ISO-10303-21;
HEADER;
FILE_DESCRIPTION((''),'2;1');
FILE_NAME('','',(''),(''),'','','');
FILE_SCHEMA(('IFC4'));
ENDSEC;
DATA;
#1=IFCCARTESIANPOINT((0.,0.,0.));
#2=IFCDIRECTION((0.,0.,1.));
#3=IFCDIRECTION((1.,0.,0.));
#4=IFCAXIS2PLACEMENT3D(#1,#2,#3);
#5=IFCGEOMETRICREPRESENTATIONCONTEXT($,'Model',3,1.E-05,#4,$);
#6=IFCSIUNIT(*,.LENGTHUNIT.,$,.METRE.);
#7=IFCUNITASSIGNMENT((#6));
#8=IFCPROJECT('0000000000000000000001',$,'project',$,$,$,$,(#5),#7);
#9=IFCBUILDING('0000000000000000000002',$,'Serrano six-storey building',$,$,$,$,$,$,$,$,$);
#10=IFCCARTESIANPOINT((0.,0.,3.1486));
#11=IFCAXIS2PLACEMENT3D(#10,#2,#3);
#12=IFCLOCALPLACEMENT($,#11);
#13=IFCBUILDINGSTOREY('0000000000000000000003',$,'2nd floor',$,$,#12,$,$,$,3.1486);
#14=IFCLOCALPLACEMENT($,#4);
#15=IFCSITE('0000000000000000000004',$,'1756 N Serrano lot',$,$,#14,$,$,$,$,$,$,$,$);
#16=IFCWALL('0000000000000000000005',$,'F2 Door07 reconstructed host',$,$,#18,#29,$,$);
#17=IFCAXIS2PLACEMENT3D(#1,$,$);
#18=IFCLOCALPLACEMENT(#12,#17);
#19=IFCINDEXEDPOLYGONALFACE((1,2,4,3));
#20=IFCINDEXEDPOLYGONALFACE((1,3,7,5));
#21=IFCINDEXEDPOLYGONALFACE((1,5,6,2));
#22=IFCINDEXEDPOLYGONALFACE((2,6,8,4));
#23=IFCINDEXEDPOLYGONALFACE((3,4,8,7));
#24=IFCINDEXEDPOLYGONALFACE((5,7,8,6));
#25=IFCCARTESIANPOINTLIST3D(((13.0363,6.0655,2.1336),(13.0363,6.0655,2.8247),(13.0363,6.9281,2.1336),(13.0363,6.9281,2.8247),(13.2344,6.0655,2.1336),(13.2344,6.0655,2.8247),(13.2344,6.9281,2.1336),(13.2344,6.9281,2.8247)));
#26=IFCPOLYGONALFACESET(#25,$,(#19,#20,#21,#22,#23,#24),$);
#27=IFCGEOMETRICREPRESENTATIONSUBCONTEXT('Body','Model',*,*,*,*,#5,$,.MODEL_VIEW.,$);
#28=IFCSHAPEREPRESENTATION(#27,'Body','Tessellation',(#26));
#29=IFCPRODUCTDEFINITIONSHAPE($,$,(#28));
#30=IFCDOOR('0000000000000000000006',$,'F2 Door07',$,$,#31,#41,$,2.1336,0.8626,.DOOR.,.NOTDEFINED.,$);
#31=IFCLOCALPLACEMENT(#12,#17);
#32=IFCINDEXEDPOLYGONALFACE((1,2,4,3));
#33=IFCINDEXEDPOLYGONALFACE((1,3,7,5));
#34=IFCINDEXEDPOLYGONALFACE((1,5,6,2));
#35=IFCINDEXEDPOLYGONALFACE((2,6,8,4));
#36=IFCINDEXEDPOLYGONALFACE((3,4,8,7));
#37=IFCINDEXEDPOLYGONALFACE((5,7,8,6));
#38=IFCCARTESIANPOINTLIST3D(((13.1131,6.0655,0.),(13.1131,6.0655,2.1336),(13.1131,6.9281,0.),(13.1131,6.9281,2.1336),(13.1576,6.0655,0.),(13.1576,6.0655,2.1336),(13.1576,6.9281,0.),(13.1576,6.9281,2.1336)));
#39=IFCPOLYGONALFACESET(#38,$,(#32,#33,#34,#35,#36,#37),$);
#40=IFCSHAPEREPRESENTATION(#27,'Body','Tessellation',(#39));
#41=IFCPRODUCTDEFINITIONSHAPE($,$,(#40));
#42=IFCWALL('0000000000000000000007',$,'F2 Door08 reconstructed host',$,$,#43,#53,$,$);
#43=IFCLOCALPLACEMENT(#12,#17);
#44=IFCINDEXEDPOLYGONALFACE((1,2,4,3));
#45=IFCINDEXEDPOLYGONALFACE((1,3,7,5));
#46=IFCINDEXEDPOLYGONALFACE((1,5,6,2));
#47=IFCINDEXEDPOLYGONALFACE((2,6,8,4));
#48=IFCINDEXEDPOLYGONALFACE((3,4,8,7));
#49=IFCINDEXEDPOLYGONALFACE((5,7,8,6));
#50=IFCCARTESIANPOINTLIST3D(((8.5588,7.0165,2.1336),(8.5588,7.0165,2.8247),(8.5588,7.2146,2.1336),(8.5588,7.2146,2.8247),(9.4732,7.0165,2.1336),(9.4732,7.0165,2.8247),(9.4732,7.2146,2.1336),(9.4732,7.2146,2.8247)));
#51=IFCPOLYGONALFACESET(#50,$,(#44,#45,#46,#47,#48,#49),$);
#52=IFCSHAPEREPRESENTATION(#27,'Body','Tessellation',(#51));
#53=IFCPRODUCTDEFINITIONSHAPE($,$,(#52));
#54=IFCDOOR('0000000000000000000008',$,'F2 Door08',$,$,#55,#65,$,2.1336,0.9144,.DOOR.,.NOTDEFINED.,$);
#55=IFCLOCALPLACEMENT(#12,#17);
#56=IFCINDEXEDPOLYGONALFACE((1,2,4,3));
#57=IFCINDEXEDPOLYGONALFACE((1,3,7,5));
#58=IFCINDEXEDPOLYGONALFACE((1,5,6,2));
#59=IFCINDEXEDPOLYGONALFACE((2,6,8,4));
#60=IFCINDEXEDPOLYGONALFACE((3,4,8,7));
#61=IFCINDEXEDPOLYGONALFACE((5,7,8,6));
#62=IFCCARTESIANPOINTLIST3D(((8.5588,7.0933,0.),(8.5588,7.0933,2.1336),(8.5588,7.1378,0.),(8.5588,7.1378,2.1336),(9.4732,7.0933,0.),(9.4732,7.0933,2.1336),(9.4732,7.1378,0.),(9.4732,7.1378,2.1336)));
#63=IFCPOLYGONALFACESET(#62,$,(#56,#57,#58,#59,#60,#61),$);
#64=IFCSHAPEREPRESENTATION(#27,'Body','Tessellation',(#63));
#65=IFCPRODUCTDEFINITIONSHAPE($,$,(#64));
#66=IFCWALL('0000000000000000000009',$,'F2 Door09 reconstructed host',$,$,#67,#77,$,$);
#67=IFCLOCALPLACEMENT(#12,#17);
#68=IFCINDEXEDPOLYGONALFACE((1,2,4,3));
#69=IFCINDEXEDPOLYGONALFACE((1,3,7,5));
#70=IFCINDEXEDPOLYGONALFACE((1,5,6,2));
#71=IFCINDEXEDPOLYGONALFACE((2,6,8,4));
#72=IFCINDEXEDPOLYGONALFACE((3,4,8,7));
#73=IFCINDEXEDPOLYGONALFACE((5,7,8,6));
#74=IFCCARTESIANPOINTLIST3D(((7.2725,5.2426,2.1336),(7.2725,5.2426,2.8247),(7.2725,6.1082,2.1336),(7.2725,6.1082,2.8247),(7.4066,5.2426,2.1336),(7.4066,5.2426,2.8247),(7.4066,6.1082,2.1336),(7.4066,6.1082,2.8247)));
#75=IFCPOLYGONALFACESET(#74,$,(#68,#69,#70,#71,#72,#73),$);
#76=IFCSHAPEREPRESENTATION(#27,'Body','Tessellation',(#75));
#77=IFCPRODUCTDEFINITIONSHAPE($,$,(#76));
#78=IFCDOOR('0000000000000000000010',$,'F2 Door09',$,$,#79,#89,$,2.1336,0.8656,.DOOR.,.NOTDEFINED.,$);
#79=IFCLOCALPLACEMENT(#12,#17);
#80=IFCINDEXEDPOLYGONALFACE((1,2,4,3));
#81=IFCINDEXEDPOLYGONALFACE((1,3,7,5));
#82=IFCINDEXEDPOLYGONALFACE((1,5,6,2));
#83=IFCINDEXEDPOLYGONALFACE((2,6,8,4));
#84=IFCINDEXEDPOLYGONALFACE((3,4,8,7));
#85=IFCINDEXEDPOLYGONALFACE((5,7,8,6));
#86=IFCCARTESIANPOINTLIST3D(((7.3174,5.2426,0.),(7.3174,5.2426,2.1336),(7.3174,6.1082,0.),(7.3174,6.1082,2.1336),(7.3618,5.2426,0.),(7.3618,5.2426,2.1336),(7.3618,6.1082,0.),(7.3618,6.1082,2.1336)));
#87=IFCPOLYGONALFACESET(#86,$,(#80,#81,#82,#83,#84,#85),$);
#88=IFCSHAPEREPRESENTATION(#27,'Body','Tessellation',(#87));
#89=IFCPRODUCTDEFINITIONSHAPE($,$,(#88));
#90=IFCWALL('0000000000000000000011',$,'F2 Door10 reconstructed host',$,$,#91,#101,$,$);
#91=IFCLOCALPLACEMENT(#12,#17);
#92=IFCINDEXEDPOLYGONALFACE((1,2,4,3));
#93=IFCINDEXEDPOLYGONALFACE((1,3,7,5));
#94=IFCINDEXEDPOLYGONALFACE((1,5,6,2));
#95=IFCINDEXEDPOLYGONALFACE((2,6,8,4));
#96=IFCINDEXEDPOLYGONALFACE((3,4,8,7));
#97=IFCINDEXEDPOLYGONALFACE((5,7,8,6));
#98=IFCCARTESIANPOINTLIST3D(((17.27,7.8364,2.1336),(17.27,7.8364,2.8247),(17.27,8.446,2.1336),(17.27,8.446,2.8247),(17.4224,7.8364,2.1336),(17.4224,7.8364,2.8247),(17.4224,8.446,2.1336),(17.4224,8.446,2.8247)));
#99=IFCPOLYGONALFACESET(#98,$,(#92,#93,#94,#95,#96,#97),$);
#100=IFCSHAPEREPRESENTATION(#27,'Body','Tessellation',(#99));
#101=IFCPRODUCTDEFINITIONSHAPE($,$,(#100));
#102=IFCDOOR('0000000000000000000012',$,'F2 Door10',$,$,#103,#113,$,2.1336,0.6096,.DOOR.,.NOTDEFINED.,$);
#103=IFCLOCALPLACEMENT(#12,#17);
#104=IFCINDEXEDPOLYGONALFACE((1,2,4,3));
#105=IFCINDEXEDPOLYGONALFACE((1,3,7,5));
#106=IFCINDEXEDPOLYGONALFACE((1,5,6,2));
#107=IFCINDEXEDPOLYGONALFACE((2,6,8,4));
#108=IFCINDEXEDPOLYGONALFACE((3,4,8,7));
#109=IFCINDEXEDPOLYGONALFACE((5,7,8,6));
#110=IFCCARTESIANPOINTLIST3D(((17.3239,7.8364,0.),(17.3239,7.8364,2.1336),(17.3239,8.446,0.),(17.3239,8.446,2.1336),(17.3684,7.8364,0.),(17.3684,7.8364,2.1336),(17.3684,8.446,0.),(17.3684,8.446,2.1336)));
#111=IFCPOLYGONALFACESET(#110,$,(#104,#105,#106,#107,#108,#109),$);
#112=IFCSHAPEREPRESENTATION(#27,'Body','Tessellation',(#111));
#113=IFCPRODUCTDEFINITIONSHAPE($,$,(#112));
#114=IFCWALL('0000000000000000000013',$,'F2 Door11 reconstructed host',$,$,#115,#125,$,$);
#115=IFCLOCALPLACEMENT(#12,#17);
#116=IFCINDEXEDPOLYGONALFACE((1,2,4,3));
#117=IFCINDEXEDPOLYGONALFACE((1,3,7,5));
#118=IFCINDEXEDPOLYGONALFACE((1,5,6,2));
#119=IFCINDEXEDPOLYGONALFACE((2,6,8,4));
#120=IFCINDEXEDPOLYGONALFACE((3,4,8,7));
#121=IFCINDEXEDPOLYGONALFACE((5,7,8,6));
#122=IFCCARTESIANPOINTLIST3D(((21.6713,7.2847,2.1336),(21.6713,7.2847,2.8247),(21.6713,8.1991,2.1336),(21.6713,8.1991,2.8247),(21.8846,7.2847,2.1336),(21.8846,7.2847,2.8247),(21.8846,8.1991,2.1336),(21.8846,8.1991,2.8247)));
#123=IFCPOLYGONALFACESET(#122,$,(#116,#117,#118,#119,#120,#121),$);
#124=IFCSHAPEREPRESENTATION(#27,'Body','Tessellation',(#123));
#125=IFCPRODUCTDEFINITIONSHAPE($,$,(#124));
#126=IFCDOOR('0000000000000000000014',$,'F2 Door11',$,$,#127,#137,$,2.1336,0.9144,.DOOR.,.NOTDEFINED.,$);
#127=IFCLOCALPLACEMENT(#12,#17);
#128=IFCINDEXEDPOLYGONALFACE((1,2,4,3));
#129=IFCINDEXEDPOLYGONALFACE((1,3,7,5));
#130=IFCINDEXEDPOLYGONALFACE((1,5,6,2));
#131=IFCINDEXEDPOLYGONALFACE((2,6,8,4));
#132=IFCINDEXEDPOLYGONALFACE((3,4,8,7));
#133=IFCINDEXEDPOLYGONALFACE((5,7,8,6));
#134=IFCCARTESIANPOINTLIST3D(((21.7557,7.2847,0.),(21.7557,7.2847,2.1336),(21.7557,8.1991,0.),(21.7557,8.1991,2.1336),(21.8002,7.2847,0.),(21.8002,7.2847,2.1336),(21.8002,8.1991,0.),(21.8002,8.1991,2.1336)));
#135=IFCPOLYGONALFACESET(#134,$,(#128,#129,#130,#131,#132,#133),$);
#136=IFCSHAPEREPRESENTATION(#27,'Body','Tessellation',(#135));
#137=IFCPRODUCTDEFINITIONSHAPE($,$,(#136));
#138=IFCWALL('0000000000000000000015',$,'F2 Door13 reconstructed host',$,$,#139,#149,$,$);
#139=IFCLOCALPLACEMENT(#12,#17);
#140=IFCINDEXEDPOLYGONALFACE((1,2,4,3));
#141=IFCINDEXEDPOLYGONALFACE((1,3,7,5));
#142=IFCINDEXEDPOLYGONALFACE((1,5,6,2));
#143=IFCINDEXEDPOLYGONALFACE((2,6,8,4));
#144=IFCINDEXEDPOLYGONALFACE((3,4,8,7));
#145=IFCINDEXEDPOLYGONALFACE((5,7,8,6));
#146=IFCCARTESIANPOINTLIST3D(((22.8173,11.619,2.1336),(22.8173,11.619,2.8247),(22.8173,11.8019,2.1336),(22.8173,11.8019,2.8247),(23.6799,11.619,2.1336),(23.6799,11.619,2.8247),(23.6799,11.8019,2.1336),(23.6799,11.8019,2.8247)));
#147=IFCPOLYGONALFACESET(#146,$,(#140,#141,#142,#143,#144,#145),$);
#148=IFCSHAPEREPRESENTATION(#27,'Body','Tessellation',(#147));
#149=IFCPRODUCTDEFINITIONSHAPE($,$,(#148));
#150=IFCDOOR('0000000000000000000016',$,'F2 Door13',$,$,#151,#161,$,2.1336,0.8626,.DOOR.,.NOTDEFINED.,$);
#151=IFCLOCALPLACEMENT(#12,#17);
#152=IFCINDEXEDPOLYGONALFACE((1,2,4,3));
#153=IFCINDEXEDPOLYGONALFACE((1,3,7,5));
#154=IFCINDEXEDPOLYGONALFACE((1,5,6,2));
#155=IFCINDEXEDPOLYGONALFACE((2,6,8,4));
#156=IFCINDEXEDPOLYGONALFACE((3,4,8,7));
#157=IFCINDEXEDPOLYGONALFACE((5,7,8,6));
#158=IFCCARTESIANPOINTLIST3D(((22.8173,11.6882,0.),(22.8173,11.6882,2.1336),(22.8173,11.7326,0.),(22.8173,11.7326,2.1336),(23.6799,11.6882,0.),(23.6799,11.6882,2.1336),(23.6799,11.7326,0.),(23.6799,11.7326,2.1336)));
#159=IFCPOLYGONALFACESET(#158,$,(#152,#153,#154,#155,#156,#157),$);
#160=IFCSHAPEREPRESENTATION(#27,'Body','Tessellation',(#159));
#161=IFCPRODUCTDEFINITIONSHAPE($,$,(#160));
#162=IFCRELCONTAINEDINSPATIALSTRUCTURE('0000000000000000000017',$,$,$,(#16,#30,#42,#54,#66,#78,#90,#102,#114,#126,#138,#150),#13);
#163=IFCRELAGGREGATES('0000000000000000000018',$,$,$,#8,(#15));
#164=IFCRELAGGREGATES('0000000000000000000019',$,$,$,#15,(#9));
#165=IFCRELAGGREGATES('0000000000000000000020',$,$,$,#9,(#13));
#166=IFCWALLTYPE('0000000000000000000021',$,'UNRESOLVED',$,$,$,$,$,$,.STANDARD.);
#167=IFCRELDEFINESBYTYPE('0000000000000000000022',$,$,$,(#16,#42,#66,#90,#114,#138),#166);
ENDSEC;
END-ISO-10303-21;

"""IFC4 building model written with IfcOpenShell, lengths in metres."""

from ifc_helpers import new_model, si_unit, frame, origin_with_axes, place, context, subcontext, project, spatial, polyline, outline, extrude, type_object, element, fill, save


model = new_model("IFC4")

# Units and contexts
model_context = context("Model", 3, precision=1e-05, world=origin_with_axes())
body_context = subcontext(model_context, "Body", "Model", "MODEL_VIEW")
ifc_project = project(units=[si_unit("LENGTHUNIT", "METRE")], contexts=[model_context])

# Site, building, storey
site_placement = place(None, origin_with_axes())
site = spatial("IfcSite", under=ifc_project, at=site_placement, Name="1756 N Serrano lot")
building = spatial("IfcBuilding", under=site, Name="Serrano six-storey building")
storey_placement = place(None, frame((0.0, 0.0, 3.1486), z_axis=(0.0, 0.0, 1.0), x_axis=(1.0, 0.0, 0.0)))
storey = spatial("IfcBuildingStorey", under=building, at=storey_placement, Name="2nd floor", Elevation=3.1486)

# Walls, openings, doors
wall_type_1 = type_object("IfcWallType", Name="UNRESOLVED", PredefinedType="STANDARD")
wall_1_placement = place(storey_placement, frame((0.0, 0.0, -3.1486), z_axis=(0.0, 0.0, 1.0), x_axis=(1.0, 0.0, 0.0)))
wall_1 = element("IfcWall", 1, at=wall_1_placement, inside=storey, type_object=wall_type_1, Name="F2 Door07 reconstructed host", context=body_context, shape_type="SweptSolid", body=[
    extrude(outline(polyline([(13.2344, 6.0655), (13.0363, 6.0655), (13.0363, 6.9281), (13.2344, 6.9281), (13.2344, 6.0655)])), frame((0.0, 0.0, 3.1486)), (0.0, 0.0, 1.0), 2.8247),
])
opening_1_placement = place(None, origin_with_axes())
opening_1 = element("IfcOpeningElement", 2, at=opening_1_placement, cuts=wall_1, PredefinedType="OPENING", context=body_context, shape_type="SweptSolid", body=[
    extrude(outline(polyline([(13.2527, 6.0655), (13.018, 6.0655), (13.018, 6.9281), (13.2527, 6.9281), (13.2527, 6.0655)])), frame((0.0, 0.0, 3.1486)), (0.0, 0.0, 1.0), 2.1336),
])
door_1_placement = place(storey_placement, frame((0.0, 0.0, -3.1486), z_axis=(0.0, 0.0, 1.0), x_axis=(1.0, 0.0, 0.0)))
door_1 = element("IfcDoor", 3, at=door_1_placement, inside=storey, Name="F2 Door07", OperationType="NOTDEFINED", OverallHeight=2.1336, OverallWidth=0.8626, PredefinedType="DOOR", context=body_context, shape_type="SweptSolid", body=[
    extrude(outline(polyline([(13.1576, 6.0655), (13.1131, 6.0655), (13.1131, 6.9281), (13.1576, 6.9281), (13.1576, 6.0655)])), frame((0.0, 0.0, 3.1486)), (0.0, 0.0, 1.0), 2.1336),
])
fill(opening_1, door_1)
wall_2_placement = place(storey_placement, frame((0.0, 0.0, -3.1486), z_axis=(0.0, 0.0, 1.0), x_axis=(1.0, 0.0, 0.0)))
wall_2 = element("IfcWall", 4, at=wall_2_placement, inside=storey, type_object=wall_type_1, Name="F2 Door08 reconstructed host", context=body_context, shape_type="SweptSolid", body=[
    extrude(outline(polyline([(9.4732, 7.2146), (9.4732, 7.0165), (8.5588, 7.0165), (8.5588, 7.2146), (9.4732, 7.2146)])), frame((0.0, 0.0, 3.1486)), (0.0, 0.0, 1.0), 2.8247),
])
opening_2_placement = place(None, origin_with_axes())
opening_2 = element("IfcOpeningElement", 5, at=opening_2_placement, cuts=wall_2, PredefinedType="OPENING", context=body_context, shape_type="SweptSolid", body=[
    extrude(outline(polyline([(9.4732, 7.2329), (9.4732, 6.9982), (8.5588, 6.9982), (8.5588, 7.2329), (9.4732, 7.2329)])), frame((0.0, 0.0, 3.1486)), (0.0, 0.0, 1.0), 2.1336),
])
door_2_placement = place(storey_placement, frame((0.0, 0.0, -3.1486), z_axis=(0.0, 0.0, 1.0), x_axis=(1.0, 0.0, 0.0)))
door_2 = element("IfcDoor", 6, at=door_2_placement, inside=storey, Name="F2 Door08", OperationType="NOTDEFINED", OverallHeight=2.1336, OverallWidth=0.9144, PredefinedType="DOOR", context=body_context, shape_type="SweptSolid", body=[
    extrude(outline(polyline([(9.4732, 7.1378), (9.4732, 7.0933), (8.5588, 7.0933), (8.5588, 7.1378), (9.4732, 7.1378)])), frame((0.0, 0.0, 3.1486)), (0.0, 0.0, 1.0), 2.1336),
])
fill(opening_2, door_2)
wall_3_placement = place(storey_placement, frame((0.0, 0.0, -3.1486), z_axis=(0.0, 0.0, 1.0), x_axis=(1.0, 0.0, 0.0)))
wall_3 = element("IfcWall", 7, at=wall_3_placement, inside=storey, type_object=wall_type_1, Name="F2 Door09 reconstructed host", context=body_context, shape_type="SweptSolid", body=[
    extrude(outline(polyline([(7.4066, 5.2426), (7.2725, 5.2426), (7.2725, 6.1082), (7.4066, 6.1082), (7.4066, 5.2426)])), frame((0.0, 0.0, 3.1486)), (0.0, 0.0, 1.0), 2.8247),
])
opening_3_placement = place(None, origin_with_axes())
opening_3 = element("IfcOpeningElement", 8, at=opening_3_placement, cuts=wall_3, PredefinedType="OPENING", context=body_context, shape_type="SweptSolid", body=[
    extrude(outline(polyline([(7.4249, 5.2426), (7.2542, 5.2426), (7.2542, 6.1082), (7.4249, 6.1082), (7.4249, 5.2426)])), frame((0.0, 0.0, 3.1486)), (0.0, 0.0, 1.0), 2.1336),
])
door_3_placement = place(storey_placement, frame((0.0, 0.0, -3.1486), z_axis=(0.0, 0.0, 1.0), x_axis=(1.0, 0.0, 0.0)))
door_3 = element("IfcDoor", 9, at=door_3_placement, inside=storey, Name="F2 Door09", OperationType="NOTDEFINED", OverallHeight=2.1336, OverallWidth=0.8656, PredefinedType="DOOR", context=body_context, shape_type="SweptSolid", body=[
    extrude(outline(polyline([(7.3618, 5.2426), (7.3174, 5.2426), (7.3174, 6.1082), (7.3618, 6.1082), (7.3618, 5.2426)])), frame((0.0, 0.0, 3.1486)), (0.0, 0.0, 1.0), 2.1336),
])
fill(opening_3, door_3)
wall_4_placement = place(storey_placement, frame((0.0, 0.0, -3.1486), z_axis=(0.0, 0.0, 1.0), x_axis=(1.0, 0.0, 0.0)))
wall_4 = element("IfcWall", 10, at=wall_4_placement, inside=storey, type_object=wall_type_1, Name="F2 Door10 reconstructed host", context=body_context, shape_type="SweptSolid", body=[
    extrude(outline(polyline([(17.4224, 7.8364), (17.27, 7.8364), (17.27, 8.446), (17.4224, 8.446), (17.4224, 7.8364)])), frame((0.0, 0.0, 3.1486)), (0.0, 0.0, 1.0), 2.8247),
])
opening_4_placement = place(None, origin_with_axes())
opening_4 = element("IfcOpeningElement", 11, at=opening_4_placement, cuts=wall_4, PredefinedType="OPENING", context=body_context, shape_type="SweptSolid", body=[
    extrude(outline(polyline([(17.4407, 7.8364), (17.2517, 7.8364), (17.2517, 8.446), (17.4407, 8.446), (17.4407, 7.8364)])), frame((0.0, 0.0, 3.1486)), (0.0, 0.0, 1.0), 2.1336),
])
door_4_placement = place(storey_placement, frame((0.0, 0.0, -3.1486), z_axis=(0.0, 0.0, 1.0), x_axis=(1.0, 0.0, 0.0)))
door_4 = element("IfcDoor", 12, at=door_4_placement, inside=storey, Name="F2 Door10", OperationType="NOTDEFINED", OverallHeight=2.1336, OverallWidth=0.6096, PredefinedType="DOOR", context=body_context, shape_type="SweptSolid", body=[
    extrude(outline(polyline([(17.3684, 7.8364), (17.3239, 7.8364), (17.3239, 8.446), (17.3684, 8.446), (17.3684, 7.8364)])), frame((0.0, 0.0, 3.1486)), (0.0, 0.0, 1.0), 2.1336),
])
fill(opening_4, door_4)
wall_5_placement = place(storey_placement, frame((0.0, 0.0, -3.1486), z_axis=(0.0, 0.0, 1.0), x_axis=(1.0, 0.0, 0.0)))
wall_5 = element("IfcWall", 13, at=wall_5_placement, inside=storey, type_object=wall_type_1, Name="F2 Door11 reconstructed host", context=body_context, shape_type="SweptSolid", body=[
    extrude(outline(polyline([(21.6713, 8.1991), (21.8846, 8.1991), (21.8846, 7.2847), (21.6713, 7.2847), (21.6713, 8.1991)])), frame((0.0, 0.0, 3.1486)), (0.0, 0.0, 1.0), 2.8247),
])
opening_5_placement = place(None, origin_with_axes())
opening_5 = element("IfcOpeningElement", 14, at=opening_5_placement, cuts=wall_5, PredefinedType="OPENING", context=body_context, shape_type="SweptSolid", body=[
    extrude(outline(polyline([(21.653, 8.1991), (21.9029, 8.1991), (21.9029, 7.2847), (21.653, 7.2847), (21.653, 8.1991)])), frame((0.0, 0.0, 3.1486)), (0.0, 0.0, 1.0), 2.1336),
])
door_5_placement = place(storey_placement, frame((0.0, 0.0, -3.1486), z_axis=(0.0, 0.0, 1.0), x_axis=(1.0, 0.0, 0.0)))
door_5 = element("IfcDoor", 15, at=door_5_placement, inside=storey, Name="F2 Door11", OperationType="NOTDEFINED", OverallHeight=2.1336, OverallWidth=0.9144, PredefinedType="DOOR", context=body_context, shape_type="SweptSolid", body=[
    extrude(outline(polyline([(21.7557, 8.1991), (21.8002, 8.1991), (21.8002, 7.2847), (21.7557, 7.2847), (21.7557, 8.1991)])), frame((0.0, 0.0, 3.1486)), (0.0, 0.0, 1.0), 2.1336),
])
fill(opening_5, door_5)
wall_6_placement = place(storey_placement, frame((0.0, 0.0, -3.1486), z_axis=(0.0, 0.0, 1.0), x_axis=(1.0, 0.0, 0.0)))
wall_6 = element("IfcWall", 16, at=wall_6_placement, inside=storey, type_object=wall_type_1, Name="F2 Door13 reconstructed host", context=body_context, shape_type="SweptSolid", body=[
    extrude(outline(polyline([(23.6799, 11.8019), (23.6799, 11.619), (22.8173, 11.619), (22.8173, 11.8019), (23.6799, 11.8019)])), frame((0.0, 0.0, 3.1486)), (0.0, 0.0, 1.0), 2.8247),
])
opening_6_placement = place(None, origin_with_axes())
opening_6 = element("IfcOpeningElement", 17, at=opening_6_placement, cuts=wall_6, PredefinedType="OPENING", context=body_context, shape_type="SweptSolid", body=[
    extrude(outline(polyline([(23.6799, 11.8201), (23.6799, 11.6007), (22.8173, 11.6007), (22.8173, 11.8201), (23.6799, 11.8201)])), frame((0.0, 0.0, 3.1486)), (0.0, 0.0, 1.0), 2.1336),
])
door_6_placement = place(storey_placement, frame((0.0, 0.0, -3.1486), z_axis=(0.0, 0.0, 1.0), x_axis=(1.0, 0.0, 0.0)))
door_6 = element("IfcDoor", 18, at=door_6_placement, inside=storey, Name="F2 Door13", OperationType="NOTDEFINED", OverallHeight=2.1336, OverallWidth=0.8626, PredefinedType="DOOR", context=body_context, shape_type="SweptSolid", body=[
    extrude(outline(polyline([(23.6799, 11.7326), (23.6799, 11.6882), (22.8173, 11.6882), (22.8173, 11.7326), (23.6799, 11.7326)])), frame((0.0, 0.0, 3.1486)), (0.0, 0.0, 1.0), 2.1336),
])
fill(opening_6, door_6)

save(model, "model.ifc")
